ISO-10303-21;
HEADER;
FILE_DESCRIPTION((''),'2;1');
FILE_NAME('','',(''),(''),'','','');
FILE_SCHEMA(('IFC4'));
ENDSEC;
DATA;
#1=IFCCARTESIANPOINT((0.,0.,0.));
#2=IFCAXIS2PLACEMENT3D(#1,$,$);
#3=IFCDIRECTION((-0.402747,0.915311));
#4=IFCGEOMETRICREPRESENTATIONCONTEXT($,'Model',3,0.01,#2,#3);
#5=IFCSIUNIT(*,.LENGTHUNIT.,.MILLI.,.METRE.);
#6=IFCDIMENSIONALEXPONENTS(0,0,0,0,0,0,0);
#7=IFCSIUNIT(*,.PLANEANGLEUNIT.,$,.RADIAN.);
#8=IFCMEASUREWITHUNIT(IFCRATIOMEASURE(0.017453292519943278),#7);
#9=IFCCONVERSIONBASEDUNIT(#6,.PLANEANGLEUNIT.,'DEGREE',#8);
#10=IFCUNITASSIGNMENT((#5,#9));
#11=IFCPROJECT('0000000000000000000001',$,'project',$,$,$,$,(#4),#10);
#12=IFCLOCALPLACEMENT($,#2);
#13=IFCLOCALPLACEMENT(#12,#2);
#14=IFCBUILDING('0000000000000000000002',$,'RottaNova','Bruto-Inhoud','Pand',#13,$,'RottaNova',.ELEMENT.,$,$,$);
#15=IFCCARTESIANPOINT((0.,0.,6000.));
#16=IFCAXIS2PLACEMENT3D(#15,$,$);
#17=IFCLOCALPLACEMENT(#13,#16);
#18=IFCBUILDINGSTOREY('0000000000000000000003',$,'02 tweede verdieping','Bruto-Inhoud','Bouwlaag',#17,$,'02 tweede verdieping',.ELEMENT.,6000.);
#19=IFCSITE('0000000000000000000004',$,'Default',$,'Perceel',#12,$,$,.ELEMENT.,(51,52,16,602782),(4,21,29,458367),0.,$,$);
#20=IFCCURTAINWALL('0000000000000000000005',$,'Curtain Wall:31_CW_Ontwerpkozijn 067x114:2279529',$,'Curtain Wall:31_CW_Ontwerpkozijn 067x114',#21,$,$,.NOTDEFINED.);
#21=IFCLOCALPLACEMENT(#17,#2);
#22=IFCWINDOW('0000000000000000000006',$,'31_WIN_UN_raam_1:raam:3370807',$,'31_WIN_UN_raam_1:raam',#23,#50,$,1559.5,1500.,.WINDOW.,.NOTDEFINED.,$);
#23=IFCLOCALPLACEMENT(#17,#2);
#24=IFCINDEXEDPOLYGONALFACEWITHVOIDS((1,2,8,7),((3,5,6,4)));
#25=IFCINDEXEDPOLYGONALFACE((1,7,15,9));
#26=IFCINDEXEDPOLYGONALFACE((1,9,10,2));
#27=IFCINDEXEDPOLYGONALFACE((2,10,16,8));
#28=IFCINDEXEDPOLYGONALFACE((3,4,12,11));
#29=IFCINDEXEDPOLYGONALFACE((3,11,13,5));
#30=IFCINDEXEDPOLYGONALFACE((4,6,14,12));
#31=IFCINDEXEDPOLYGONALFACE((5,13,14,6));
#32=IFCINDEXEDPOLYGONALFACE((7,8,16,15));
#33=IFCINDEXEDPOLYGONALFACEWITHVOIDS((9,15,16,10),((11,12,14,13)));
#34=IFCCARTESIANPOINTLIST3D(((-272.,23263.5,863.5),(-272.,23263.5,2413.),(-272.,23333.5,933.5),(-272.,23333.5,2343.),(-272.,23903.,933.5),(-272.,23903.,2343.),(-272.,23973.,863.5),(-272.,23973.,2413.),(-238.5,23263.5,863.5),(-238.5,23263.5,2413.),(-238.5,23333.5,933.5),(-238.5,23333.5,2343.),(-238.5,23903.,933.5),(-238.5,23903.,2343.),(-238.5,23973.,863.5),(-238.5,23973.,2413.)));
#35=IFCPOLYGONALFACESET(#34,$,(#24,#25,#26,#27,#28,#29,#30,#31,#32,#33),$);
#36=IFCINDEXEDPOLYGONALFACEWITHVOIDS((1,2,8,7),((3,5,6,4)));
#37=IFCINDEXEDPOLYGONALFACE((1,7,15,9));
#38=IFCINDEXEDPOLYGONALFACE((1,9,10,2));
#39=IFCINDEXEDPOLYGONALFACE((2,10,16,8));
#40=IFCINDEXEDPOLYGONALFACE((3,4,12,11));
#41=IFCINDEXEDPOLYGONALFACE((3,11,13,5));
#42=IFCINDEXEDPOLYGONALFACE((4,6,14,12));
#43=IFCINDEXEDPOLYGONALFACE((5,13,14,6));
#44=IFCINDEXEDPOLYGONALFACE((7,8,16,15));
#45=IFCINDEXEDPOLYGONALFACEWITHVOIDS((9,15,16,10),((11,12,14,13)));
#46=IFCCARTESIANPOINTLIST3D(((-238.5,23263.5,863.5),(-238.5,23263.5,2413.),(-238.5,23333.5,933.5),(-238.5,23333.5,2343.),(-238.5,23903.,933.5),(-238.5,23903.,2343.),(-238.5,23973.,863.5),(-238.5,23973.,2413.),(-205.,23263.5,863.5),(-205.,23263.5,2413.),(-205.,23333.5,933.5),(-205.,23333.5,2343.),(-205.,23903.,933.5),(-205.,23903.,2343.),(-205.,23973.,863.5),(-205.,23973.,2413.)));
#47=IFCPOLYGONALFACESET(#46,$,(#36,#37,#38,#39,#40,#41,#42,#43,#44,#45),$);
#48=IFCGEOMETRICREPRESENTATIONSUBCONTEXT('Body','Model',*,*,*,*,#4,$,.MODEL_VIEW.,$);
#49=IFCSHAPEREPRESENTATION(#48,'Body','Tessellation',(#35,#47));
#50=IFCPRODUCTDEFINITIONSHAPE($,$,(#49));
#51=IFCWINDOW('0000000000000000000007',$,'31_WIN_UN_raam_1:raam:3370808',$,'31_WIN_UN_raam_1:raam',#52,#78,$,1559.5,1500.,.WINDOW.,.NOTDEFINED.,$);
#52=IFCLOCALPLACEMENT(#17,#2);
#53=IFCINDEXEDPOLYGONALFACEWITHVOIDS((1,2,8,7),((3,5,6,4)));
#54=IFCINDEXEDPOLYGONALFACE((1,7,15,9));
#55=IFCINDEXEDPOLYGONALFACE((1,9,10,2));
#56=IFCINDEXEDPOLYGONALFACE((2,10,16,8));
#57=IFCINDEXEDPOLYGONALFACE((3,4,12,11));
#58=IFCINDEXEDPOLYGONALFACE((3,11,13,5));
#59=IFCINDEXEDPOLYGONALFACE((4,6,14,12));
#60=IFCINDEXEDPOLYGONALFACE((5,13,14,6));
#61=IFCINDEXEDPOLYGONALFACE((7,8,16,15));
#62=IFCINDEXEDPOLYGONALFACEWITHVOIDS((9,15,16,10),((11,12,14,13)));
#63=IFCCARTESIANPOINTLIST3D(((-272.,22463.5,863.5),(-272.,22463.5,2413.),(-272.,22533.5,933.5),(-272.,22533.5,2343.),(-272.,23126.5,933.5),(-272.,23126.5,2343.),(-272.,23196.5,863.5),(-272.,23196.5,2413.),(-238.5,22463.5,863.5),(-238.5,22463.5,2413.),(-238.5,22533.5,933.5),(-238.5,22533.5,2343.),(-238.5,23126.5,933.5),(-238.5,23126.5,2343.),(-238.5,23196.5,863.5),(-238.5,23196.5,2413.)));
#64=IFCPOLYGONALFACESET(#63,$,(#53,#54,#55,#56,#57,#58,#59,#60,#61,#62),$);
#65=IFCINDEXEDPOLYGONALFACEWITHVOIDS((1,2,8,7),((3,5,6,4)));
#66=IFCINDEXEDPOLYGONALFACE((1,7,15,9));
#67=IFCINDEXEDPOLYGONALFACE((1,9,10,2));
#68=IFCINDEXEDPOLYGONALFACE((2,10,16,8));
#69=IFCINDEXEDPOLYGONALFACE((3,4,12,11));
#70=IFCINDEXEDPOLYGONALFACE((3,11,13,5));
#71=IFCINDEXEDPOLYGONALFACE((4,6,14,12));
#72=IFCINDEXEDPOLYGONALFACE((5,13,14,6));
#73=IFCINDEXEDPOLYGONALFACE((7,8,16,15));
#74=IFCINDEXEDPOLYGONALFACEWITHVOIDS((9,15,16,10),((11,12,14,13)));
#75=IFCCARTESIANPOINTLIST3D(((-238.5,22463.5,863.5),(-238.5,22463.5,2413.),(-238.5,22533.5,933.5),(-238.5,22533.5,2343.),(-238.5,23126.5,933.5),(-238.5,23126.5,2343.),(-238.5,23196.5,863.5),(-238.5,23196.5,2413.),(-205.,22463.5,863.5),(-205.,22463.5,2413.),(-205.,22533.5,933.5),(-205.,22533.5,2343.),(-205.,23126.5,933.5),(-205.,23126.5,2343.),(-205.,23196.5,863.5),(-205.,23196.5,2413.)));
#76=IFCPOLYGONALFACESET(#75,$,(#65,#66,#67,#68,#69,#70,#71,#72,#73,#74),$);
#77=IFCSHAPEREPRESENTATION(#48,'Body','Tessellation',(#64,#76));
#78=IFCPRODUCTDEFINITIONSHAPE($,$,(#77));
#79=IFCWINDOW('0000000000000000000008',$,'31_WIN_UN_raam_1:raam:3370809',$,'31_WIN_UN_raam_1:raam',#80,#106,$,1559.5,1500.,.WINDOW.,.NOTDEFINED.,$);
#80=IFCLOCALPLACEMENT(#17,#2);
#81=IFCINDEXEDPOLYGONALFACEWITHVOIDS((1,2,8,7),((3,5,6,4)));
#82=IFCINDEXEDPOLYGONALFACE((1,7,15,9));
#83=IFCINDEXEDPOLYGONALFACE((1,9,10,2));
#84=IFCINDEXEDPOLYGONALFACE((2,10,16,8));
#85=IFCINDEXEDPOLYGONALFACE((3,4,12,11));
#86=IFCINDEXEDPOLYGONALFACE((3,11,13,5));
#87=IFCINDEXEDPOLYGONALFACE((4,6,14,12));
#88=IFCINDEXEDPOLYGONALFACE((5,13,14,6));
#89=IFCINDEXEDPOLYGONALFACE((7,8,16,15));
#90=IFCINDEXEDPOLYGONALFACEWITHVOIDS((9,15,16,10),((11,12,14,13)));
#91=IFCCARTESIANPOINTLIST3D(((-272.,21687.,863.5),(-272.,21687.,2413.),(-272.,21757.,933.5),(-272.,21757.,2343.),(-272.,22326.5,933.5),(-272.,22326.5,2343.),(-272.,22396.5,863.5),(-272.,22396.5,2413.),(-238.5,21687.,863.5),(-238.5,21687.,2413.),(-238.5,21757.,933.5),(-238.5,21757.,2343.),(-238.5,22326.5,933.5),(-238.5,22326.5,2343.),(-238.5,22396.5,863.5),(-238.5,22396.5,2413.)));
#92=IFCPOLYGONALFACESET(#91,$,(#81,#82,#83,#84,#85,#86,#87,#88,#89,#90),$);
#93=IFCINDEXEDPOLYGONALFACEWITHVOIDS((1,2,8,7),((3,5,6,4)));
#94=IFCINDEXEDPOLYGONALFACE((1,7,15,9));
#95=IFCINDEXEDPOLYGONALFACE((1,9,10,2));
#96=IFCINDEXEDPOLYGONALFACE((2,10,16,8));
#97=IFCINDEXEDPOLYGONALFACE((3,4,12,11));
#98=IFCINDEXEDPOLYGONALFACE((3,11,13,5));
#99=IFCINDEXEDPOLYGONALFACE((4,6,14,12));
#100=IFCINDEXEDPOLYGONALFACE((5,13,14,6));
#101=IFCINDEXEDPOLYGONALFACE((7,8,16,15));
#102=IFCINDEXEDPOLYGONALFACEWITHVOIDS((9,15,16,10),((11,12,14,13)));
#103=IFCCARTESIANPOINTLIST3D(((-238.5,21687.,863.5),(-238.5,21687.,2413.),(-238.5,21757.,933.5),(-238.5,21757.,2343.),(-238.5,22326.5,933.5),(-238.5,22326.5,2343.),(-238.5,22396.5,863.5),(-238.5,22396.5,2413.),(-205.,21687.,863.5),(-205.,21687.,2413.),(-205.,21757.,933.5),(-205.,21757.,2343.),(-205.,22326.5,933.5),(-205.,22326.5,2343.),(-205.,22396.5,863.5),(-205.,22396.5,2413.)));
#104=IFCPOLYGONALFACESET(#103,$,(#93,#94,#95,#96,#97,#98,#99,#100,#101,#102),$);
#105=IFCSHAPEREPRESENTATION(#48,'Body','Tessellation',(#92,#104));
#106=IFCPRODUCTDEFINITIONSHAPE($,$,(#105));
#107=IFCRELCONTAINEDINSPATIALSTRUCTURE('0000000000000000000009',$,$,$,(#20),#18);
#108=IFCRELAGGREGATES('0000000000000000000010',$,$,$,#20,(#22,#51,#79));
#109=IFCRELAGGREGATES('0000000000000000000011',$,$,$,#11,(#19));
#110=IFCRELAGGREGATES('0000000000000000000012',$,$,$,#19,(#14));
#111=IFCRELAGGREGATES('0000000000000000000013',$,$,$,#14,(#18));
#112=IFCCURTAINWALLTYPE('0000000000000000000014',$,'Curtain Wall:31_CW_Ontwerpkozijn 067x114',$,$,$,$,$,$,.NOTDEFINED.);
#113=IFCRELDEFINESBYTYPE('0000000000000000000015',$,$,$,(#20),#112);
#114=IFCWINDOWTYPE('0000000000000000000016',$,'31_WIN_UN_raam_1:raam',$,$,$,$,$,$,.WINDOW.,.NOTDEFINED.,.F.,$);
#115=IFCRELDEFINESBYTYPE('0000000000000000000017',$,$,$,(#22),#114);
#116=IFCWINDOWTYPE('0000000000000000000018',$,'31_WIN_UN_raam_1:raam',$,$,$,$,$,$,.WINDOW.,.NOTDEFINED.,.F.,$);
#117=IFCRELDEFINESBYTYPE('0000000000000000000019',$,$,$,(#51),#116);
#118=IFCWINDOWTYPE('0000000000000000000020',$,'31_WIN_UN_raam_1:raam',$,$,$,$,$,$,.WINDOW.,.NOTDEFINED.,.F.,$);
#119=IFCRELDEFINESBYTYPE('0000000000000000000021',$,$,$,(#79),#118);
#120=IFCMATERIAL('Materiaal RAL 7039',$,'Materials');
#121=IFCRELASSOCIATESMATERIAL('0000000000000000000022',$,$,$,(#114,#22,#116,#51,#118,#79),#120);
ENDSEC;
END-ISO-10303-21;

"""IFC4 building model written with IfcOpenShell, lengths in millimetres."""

from ifc_helpers import new_model, entity, si_unit, converted_unit, direction, frame, origin, place, context, subcontext, project, spatial, polyline, outline, extrude, source, transform, mapped, material, type_object, type_shapes, element, aggregate, save


model = new_model("IFC4")

# Units and contexts
model_context = context("Model", 3, precision=0.01, world=origin(), true_north=direction((-0.402747, 0.915311)))
body_context = subcontext(model_context, "Body", "Model", "MODEL_VIEW")
ifc_project = project(units=[si_unit("LENGTHUNIT", "METRE", prefix="MILLI"), converted_unit("PLANEANGLEUNIT", "DEGREE", entity("IfcRatioMeasure", 0.017453292519943278), si_unit("PLANEANGLEUNIT", "RADIAN"), dimensions=[0, 0, 0, 0, 0, 0, 0])], contexts=[model_context])

# Site, building, storey
site_placement = place(None, origin())
site = spatial("IfcSite", under=ifc_project, at=site_placement, Name="Default", ObjectType="Perceel", CompositionType="ELEMENT", RefLatitude=(51, 52, 16, 602782), RefLongitude=(4, 21, 29, 458367), RefElevation=0.0)
building_placement = place(site_placement, origin())
building = spatial("IfcBuilding", under=site, at=building_placement, Name="RottaNova", Description="Bruto-Inhoud", ObjectType="Pand", LongName="RottaNova", CompositionType="ELEMENT")
storey_placement = place(building_placement, frame((0.0, 0.0, 6000.0)))
storey = spatial("IfcBuildingStorey", under=building, at=storey_placement, Name="02 tweede verdieping", Description="Bruto-Inhoud", ObjectType="Bouwlaag", LongName="02 tweede verdieping", CompositionType="ELEMENT", Elevation=6000.0)

# Curtain wall
curtain_wall_type = type_object("IfcCurtainWallType", Name="Curtain Wall:31_CW_Ontwerpkozijn 067x114", PredefinedType="NOTDEFINED")
curtain_wall_1_placement = place(storey_placement, frame((0.0, 0.0, -6000.0)))
curtain_wall_1 = element("IfcCurtainWall", 1, at=curtain_wall_1_placement, inside=storey, type_object=curtain_wall_type, Name="Curtain Wall:31_CW_Ontwerpkozijn 067x114:2279529", ObjectType="Curtain Wall:31_CW_Ontwerpkozijn 067x114", PredefinedType="NOTDEFINED")

# Windows
ifc_material_1 = material(Name="Materiaal RAL 7039", Category="Materials")
window_type_1 = type_object("IfcWindowType", Name="31_WIN_UN_raam_1:raam", ParameterTakesPrecedence=False, PartitioningType="NOTDEFINED", PredefinedType="WINDOW", material=ifc_material_1)
shared_shape_1 = source(origin(), body_context, "Body", "SweptSolid", [
    extrude(outline(polyline([(-354.7, -774.7), (354.7, -774.7), (354.7, 774.7), (-354.7, 774.7), (-354.7, -774.7)]), holes=[polyline([(-284.7, 704.7), (284.7, 704.7), (284.7, -704.8), (-284.7, -704.8), (-284.7, 704.7)])]), frame((0.0, 92.0, 774.8), z_axis=(0.0, -1.0, 0.0), x_axis=(-1.0, 0.0, 0.0)), (0.0, 0.0, 1.0), 33.5),
    extrude(outline(polyline([(-354.7, -774.7), (354.7, -774.7), (354.7, 774.7), (-354.7, 774.7), (-354.7, -774.7)]), holes=[polyline([(-284.7, 704.7), (284.7, 704.7), (284.7, -704.8), (-284.7, -704.8), (-284.7, 704.7)])]), frame((0.0, 58.5, 774.8), z_axis=(0.0, -1.0, 0.0), x_axis=(-1.0, 0.0, 0.0)), (0.0, 0.0, 1.0), 33.5),
])
type_shapes(window_type_1, [shared_shape_1])
window_1_placement = place(curtain_wall_1_placement, frame((-180.0, 23618.2, 6863.5), z_axis=(0.0, 0.0, 1.0), x_axis=(0.0, 1.0, 0.0)))
window_1 = element("IfcWindow", 2, at=window_1_placement, type_object=window_type_1, material=ifc_material_1, Name="31_WIN_UN_raam_1:raam:3370807", ObjectType="31_WIN_UN_raam_1:raam", OverallHeight=1559.5, OverallWidth=1500.0, PartitioningType="NOTDEFINED", PredefinedType="WINDOW", context=body_context, shape_type="MappedRepresentation", body=[
    mapped(shared_shape_1, transform((0.0, 0.0, 0.0), scale=1.0)),
])
window_type_2 = type_object("IfcWindowType", Name="31_WIN_UN_raam_1:raam", ParameterTakesPrecedence=False, PartitioningType="NOTDEFINED", PredefinedType="WINDOW", material=ifc_material_1)
shared_shape_2 = source(origin(), body_context, "Body", "SweptSolid", [
    extrude(outline(polyline([(-366.5, -774.7), (366.5, -774.7), (366.5, 774.7), (-366.5, 774.7), (-366.5, -774.7)]), holes=[polyline([(-296.5, 704.7), (296.5, 704.7), (296.5, -704.8), (-296.5, -704.8), (-296.5, 704.7)])]), frame((0.0, 92.0, 774.8), z_axis=(0.0, -1.0, 0.0), x_axis=(-1.0, 0.0, 0.0)), (0.0, 0.0, 1.0), 33.5),
    extrude(outline(polyline([(-366.5, -774.7), (366.5, -774.7), (366.5, 774.7), (-366.5, 774.7), (-366.5, -774.7)]), holes=[polyline([(-296.5, 704.7), (296.5, 704.7), (296.5, -704.8), (-296.5, -704.8), (-296.5, 704.7)])]), frame((0.0, 58.5, 774.8), z_axis=(0.0, -1.0, 0.0), x_axis=(-1.0, 0.0, 0.0)), (0.0, 0.0, 1.0), 33.5),
])
type_shapes(window_type_2, [shared_shape_2])
window_2_placement = place(curtain_wall_1_placement, frame((-180.0, 22830.0, 6863.5), z_axis=(0.0, 0.0, 1.0), x_axis=(0.0, 1.0, 0.0)))
window_2 = element("IfcWindow", 3, at=window_2_placement, type_object=window_type_2, material=ifc_material_1, Name="31_WIN_UN_raam_1:raam:3370808", ObjectType="31_WIN_UN_raam_1:raam", OverallHeight=1559.5, OverallWidth=1500.0, PartitioningType="NOTDEFINED", PredefinedType="WINDOW", context=body_context, shape_type="MappedRepresentation", body=[
    mapped(shared_shape_2, transform((0.0, 0.0, 0.0), scale=1.0)),
])
window_type_3 = type_object("IfcWindowType", Name="31_WIN_UN_raam_1:raam", ParameterTakesPrecedence=False, PartitioningType="NOTDEFINED", PredefinedType="WINDOW", material=ifc_material_1)
shared_shape_3 = source(origin(), body_context, "Body", "SweptSolid", [
    extrude(outline(polyline([(-354.7, -774.7), (354.7, -774.7), (354.7, 774.7), (-354.7, 774.7), (-354.7, -774.7)]), holes=[polyline([(-284.7, 704.7), (284.7, 704.7), (284.7, -704.8), (-284.7, -704.8), (-284.7, 704.7)])]), frame((0.0, 92.0, 774.8), z_axis=(0.0, -1.0, 0.0), x_axis=(-1.0, 0.0, 0.0)), (0.0, 0.0, 1.0), 33.5),
    extrude(outline(polyline([(-354.7, -774.7), (354.7, -774.7), (354.7, 774.7), (-354.7, 774.7), (-354.7, -774.7)]), holes=[polyline([(-284.7, 704.7), (284.7, 704.7), (284.7, -704.8), (-284.7, -704.8), (-284.7, 704.7)])]), frame((0.0, 58.5, 774.8), z_axis=(0.0, -1.0, 0.0), x_axis=(-1.0, 0.0, 0.0)), (0.0, 0.0, 1.0), 33.5),
])
type_shapes(window_type_3, [shared_shape_3])
window_3_placement = place(curtain_wall_1_placement, frame((-180.0, 22041.7, 6863.5), z_axis=(0.0, 0.0, 1.0), x_axis=(0.0, 1.0, 0.0)))
window_3 = element("IfcWindow", 4, at=window_3_placement, type_object=window_type_3, material=ifc_material_1, Name="31_WIN_UN_raam_1:raam:3370809", ObjectType="31_WIN_UN_raam_1:raam", OverallHeight=1559.5, OverallWidth=1500.0, PartitioningType="NOTDEFINED", PredefinedType="WINDOW", context=body_context, shape_type="MappedRepresentation", body=[
    mapped(shared_shape_3, transform((0.0, 0.0, 0.0), scale=1.0)),
])
aggregate(curtain_wall_1, [window_1, window_2, window_3])

save(model, "model.ifc")
